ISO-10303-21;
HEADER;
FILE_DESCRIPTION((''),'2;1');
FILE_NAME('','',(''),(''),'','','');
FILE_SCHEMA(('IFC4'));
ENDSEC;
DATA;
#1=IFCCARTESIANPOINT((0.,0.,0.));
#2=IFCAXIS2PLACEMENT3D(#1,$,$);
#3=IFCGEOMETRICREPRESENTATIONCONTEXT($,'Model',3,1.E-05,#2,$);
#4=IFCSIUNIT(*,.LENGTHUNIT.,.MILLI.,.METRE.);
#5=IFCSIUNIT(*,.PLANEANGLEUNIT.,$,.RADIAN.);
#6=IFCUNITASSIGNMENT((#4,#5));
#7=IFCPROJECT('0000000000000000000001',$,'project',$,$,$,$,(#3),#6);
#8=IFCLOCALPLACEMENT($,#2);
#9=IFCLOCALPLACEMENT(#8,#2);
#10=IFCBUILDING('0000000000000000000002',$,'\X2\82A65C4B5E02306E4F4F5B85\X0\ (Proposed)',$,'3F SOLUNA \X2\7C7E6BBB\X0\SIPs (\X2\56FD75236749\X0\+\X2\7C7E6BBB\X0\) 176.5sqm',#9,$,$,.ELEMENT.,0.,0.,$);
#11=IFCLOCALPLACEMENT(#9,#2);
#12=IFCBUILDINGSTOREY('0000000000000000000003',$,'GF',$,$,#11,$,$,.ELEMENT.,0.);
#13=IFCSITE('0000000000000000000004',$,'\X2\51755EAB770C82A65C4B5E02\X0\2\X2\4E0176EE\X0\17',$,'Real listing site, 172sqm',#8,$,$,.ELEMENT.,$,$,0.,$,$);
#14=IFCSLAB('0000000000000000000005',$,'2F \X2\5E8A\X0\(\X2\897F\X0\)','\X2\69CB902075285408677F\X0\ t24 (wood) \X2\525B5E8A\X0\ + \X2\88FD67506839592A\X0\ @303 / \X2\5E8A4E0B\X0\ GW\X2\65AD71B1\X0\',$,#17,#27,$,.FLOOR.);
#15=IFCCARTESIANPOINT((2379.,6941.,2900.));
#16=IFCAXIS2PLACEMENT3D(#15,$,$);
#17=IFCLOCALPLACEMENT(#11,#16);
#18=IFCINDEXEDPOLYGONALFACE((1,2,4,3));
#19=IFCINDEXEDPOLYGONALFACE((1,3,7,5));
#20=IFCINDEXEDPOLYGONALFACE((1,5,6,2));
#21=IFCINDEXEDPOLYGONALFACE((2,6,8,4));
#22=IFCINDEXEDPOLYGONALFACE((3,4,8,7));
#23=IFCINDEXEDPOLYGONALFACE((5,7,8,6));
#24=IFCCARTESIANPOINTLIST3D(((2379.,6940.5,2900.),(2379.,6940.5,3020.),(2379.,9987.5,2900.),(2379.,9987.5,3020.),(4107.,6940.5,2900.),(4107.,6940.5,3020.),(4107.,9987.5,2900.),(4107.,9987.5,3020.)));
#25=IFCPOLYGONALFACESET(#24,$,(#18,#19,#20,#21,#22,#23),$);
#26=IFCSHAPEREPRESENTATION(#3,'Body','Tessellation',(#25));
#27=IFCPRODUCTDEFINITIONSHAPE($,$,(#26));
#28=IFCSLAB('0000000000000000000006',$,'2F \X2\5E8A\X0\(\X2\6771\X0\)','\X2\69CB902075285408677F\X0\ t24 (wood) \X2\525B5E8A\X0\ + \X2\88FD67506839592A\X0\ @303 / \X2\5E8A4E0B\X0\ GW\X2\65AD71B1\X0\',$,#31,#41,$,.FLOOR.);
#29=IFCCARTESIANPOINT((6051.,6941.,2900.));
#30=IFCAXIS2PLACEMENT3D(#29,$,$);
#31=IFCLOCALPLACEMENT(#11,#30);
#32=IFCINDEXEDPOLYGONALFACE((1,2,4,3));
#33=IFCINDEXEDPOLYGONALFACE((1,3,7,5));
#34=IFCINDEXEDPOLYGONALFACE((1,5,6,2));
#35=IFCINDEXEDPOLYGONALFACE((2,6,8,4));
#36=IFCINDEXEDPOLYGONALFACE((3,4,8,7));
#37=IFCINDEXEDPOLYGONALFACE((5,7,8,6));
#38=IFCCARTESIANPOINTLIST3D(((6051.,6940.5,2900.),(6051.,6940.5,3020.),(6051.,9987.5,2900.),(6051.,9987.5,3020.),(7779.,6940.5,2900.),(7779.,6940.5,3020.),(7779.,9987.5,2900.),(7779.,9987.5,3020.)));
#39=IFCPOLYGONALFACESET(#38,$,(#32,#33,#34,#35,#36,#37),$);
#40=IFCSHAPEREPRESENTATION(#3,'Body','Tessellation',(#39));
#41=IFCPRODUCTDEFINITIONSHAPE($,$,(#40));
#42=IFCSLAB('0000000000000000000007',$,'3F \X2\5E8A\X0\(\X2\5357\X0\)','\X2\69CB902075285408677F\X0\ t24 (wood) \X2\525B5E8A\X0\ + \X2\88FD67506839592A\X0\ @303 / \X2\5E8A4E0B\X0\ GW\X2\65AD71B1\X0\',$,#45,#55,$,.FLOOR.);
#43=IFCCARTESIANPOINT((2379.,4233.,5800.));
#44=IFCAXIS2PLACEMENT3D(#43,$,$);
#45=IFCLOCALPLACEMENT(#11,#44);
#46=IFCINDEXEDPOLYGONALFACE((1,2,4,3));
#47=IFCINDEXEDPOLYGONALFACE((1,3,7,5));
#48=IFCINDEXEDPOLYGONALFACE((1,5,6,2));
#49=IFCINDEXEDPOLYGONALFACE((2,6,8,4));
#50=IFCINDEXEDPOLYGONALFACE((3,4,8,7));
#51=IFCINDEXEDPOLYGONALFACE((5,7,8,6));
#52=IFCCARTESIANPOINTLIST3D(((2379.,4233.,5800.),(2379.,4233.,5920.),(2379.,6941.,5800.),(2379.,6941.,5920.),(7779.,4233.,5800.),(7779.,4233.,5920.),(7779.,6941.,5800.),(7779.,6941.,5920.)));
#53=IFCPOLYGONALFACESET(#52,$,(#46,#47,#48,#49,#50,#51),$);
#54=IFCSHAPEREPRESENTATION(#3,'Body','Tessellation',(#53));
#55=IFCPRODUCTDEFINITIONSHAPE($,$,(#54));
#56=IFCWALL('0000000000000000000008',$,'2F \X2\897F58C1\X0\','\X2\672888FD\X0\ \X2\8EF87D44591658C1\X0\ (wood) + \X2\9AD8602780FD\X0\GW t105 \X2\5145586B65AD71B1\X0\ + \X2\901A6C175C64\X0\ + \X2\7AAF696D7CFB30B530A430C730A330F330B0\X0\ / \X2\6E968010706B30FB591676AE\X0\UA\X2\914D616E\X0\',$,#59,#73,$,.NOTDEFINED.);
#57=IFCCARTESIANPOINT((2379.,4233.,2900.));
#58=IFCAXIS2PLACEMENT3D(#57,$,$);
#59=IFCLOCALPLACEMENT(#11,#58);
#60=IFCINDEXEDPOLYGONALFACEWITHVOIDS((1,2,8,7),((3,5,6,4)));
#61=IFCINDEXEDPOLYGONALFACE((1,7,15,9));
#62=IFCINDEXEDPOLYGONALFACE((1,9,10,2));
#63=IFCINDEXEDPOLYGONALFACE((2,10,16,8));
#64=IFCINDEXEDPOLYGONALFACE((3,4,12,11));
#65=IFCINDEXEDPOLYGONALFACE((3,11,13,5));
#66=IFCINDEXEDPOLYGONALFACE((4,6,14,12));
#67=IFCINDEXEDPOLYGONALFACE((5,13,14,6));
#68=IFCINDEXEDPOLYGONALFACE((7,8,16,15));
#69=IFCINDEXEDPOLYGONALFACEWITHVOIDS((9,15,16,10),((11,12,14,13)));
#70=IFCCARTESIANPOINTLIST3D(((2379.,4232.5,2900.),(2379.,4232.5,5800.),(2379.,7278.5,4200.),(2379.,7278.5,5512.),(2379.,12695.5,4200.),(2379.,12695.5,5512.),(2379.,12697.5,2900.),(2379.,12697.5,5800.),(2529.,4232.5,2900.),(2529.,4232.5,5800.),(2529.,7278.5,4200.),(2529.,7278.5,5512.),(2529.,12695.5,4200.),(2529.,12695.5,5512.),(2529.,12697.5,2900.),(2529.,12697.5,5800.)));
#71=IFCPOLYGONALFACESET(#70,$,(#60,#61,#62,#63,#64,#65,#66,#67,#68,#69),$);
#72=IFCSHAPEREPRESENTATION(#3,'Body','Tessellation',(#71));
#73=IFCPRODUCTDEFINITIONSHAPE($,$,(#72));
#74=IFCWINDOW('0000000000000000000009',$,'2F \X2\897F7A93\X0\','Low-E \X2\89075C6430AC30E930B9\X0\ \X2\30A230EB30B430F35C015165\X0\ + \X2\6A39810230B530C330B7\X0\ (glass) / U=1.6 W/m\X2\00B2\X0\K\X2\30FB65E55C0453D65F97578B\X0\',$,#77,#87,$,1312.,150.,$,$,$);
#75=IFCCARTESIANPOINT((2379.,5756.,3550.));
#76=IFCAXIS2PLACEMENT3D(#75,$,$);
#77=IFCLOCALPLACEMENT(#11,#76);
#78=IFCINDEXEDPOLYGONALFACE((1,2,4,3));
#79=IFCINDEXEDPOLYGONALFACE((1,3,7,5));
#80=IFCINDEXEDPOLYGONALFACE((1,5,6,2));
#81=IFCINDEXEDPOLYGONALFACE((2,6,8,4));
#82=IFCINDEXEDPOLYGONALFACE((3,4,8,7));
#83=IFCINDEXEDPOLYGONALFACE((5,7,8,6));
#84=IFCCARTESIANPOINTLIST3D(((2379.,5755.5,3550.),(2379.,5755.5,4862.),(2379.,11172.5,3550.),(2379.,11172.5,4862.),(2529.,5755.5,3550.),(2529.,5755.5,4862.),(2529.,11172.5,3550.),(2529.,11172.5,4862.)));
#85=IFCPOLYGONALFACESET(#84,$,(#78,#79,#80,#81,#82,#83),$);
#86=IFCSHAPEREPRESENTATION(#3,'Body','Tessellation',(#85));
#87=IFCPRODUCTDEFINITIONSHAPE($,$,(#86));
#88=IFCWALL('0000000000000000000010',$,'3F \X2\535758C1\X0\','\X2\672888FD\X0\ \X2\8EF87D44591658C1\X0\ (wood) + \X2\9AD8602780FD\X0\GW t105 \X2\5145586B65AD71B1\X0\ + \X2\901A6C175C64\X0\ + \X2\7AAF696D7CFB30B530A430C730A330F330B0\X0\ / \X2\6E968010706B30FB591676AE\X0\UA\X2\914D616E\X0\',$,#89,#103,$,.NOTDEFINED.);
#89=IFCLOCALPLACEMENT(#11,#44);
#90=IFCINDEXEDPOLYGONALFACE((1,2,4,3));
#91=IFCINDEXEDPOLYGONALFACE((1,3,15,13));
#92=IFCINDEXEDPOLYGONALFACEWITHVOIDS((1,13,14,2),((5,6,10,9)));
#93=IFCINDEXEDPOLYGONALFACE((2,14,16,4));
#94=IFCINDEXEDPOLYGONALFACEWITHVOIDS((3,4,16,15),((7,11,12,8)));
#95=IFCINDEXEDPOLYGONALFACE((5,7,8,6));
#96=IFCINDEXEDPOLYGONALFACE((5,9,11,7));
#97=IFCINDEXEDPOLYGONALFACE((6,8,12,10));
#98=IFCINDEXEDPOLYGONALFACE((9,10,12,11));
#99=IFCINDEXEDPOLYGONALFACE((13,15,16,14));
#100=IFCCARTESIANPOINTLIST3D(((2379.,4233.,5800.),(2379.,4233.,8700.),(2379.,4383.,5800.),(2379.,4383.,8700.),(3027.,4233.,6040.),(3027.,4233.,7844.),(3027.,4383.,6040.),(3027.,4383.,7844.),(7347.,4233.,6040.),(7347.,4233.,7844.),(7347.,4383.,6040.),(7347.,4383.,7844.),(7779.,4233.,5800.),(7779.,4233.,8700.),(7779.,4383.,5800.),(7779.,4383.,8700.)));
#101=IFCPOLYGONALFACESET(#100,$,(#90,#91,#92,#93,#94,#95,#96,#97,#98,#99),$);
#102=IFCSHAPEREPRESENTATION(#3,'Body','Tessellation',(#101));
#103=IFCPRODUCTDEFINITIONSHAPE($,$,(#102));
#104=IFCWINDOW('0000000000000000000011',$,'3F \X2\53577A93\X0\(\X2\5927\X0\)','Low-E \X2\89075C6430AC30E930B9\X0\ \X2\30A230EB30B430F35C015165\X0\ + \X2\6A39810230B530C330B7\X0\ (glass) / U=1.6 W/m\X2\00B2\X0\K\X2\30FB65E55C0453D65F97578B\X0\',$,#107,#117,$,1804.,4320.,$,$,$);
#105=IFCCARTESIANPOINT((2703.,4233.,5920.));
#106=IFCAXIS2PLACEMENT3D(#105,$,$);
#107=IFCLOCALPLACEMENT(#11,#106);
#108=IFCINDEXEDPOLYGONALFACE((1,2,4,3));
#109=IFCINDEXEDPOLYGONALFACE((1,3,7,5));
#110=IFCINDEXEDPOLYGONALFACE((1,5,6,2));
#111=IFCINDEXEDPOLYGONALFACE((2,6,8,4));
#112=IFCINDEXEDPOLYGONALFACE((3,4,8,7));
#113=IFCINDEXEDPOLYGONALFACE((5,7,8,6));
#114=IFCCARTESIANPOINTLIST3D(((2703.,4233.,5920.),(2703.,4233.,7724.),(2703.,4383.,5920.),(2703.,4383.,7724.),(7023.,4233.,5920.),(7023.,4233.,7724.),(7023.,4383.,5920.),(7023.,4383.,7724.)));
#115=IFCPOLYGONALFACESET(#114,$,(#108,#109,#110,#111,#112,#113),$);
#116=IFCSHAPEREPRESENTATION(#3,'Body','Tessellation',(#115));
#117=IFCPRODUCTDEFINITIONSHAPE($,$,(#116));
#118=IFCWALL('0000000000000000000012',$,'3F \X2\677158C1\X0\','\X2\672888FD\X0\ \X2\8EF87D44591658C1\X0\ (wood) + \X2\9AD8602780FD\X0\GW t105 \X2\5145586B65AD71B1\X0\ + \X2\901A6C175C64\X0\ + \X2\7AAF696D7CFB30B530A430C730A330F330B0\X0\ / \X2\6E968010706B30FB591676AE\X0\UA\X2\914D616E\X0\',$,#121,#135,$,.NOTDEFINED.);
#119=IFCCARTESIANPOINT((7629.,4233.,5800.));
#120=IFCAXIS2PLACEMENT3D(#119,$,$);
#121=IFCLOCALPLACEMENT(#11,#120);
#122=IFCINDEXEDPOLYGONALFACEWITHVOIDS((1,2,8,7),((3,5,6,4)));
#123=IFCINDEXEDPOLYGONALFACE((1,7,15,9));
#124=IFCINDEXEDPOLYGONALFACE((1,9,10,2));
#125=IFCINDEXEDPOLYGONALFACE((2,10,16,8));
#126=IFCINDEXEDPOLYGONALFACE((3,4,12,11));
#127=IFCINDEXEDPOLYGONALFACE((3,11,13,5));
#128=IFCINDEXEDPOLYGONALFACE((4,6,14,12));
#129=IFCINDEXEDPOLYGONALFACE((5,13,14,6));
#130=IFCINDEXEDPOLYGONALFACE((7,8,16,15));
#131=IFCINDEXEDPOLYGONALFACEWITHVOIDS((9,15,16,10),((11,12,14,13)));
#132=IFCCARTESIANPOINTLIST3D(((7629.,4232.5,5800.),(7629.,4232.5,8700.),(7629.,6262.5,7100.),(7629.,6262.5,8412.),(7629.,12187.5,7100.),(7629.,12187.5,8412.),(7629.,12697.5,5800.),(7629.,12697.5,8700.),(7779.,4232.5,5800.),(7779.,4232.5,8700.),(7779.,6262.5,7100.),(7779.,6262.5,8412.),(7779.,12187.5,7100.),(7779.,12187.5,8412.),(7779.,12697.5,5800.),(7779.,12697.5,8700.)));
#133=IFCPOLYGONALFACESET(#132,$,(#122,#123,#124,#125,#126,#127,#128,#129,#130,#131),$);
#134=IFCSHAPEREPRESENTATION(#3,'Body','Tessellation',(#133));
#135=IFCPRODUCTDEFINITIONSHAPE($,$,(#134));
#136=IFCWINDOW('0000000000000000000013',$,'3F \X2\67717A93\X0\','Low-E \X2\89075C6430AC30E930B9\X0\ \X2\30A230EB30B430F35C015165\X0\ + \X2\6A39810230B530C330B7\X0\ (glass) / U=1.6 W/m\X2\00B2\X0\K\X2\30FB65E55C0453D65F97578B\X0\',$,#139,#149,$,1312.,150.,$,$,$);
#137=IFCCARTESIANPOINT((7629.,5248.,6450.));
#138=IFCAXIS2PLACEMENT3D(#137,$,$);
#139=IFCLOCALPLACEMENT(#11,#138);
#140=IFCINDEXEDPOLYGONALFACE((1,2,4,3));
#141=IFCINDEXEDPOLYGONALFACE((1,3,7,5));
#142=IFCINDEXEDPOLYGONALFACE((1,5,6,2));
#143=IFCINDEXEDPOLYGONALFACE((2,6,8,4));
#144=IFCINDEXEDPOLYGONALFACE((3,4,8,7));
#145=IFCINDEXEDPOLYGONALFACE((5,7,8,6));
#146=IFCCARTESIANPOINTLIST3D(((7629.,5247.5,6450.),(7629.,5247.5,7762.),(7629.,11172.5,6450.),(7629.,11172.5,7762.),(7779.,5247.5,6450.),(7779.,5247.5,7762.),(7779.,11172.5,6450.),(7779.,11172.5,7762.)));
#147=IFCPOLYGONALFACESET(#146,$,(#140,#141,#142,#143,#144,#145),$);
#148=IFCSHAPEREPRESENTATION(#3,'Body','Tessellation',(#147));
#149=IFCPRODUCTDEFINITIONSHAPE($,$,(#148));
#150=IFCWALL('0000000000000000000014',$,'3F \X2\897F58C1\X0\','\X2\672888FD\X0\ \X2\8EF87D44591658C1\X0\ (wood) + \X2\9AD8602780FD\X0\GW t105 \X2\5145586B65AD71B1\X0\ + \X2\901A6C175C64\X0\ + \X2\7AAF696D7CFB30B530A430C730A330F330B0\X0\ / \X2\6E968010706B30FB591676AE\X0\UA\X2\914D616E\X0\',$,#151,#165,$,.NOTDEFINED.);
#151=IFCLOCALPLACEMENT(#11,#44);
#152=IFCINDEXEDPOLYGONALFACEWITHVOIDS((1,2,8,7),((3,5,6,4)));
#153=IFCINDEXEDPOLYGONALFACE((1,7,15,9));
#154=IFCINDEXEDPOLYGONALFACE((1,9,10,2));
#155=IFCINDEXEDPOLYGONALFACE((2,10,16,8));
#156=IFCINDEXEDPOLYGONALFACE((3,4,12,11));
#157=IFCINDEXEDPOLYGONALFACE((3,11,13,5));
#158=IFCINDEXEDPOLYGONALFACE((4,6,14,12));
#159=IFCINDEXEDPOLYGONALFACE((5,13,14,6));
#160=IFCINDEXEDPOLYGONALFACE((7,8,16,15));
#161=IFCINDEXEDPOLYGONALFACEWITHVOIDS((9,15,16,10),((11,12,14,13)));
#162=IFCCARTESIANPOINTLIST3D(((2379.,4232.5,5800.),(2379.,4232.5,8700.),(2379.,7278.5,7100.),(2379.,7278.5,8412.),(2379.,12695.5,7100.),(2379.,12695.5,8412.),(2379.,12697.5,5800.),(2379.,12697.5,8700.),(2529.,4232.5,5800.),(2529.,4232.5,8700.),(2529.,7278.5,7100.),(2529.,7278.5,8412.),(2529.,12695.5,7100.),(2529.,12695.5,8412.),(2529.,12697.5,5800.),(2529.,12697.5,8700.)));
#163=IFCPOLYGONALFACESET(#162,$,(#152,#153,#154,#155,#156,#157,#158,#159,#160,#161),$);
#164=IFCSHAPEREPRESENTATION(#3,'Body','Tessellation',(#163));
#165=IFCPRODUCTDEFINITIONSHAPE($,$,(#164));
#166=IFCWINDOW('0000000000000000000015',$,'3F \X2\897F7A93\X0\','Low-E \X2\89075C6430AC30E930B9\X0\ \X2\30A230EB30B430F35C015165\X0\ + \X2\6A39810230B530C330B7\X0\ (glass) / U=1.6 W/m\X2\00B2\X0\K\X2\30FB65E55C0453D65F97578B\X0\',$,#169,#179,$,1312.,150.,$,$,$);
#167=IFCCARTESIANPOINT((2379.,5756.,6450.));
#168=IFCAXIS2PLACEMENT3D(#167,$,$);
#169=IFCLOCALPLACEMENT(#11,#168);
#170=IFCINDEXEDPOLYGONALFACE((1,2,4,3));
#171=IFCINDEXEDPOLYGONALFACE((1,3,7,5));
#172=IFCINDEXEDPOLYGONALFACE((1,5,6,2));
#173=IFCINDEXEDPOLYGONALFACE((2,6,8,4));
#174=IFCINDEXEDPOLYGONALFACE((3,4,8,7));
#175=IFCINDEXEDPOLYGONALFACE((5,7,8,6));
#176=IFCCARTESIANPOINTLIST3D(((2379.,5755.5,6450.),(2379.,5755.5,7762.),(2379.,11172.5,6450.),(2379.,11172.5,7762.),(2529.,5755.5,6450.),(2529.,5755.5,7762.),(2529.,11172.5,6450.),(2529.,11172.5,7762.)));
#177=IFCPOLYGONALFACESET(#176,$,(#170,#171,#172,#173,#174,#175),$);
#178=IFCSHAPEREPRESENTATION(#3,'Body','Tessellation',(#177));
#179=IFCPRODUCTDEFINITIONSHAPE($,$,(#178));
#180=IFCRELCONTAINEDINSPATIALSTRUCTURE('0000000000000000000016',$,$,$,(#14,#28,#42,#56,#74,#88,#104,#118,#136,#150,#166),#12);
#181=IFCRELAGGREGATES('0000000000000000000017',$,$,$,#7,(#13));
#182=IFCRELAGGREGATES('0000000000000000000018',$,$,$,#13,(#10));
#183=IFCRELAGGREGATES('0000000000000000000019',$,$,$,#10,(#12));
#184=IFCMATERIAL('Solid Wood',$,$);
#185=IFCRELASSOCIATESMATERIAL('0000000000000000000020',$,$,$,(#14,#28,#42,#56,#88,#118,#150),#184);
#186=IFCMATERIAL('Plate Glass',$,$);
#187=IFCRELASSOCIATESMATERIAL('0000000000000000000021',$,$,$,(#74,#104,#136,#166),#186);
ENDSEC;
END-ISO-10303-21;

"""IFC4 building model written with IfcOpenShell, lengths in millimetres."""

from ifc_helpers import new_model, si_unit, frame, frame_2d, origin, place, context, project, spatial, rectangle, extrude, material, element, fill, save


model = new_model("IFC4")

# Units and contexts
model_context = context("Model", 3, precision=1e-05, world=origin())
ifc_project = project(units=[si_unit("LENGTHUNIT", "METRE", prefix="MILLI"), si_unit("PLANEANGLEUNIT", "RADIAN")], contexts=[model_context])

# Site, building, storey
site_placement = place(None, origin())
site = spatial("IfcSite", under=ifc_project, at=site_placement, Name="兵庫県芦屋市2丁目17", ObjectType="Real listing site, 172sqm", CompositionType="ELEMENT", RefElevation=0.0)
building_placement = place(site_placement, origin())
building = spatial("IfcBuilding", under=site, at=building_placement, Name="芦屋市の住宅 (Proposed)", ObjectType="3F SOLUNA 籾殻SIPs (国産杉+籾殻) 176.5sqm", CompositionType="ELEMENT", ElevationOfRefHeight=0.0, ElevationOfTerrain=0.0)
storey_placement = place(building_placement, origin())
storey = spatial("IfcBuildingStorey", under=building, at=storey_placement, Name="GF", CompositionType="ELEMENT", Elevation=0.0)

# Slabs
ifc_material_1 = material(Name="Solid Wood")
slab_1_placement = place(storey_placement, frame((2379.0, 6941.0, 2900.0)))
element("IfcSlab", 1, at=slab_1_placement, inside=storey, material=ifc_material_1, Name="2F 床(西)", Description="構造用合板 t24 (wood) 剛床 + 製材根太 @303 / 床下 GW断熱", PredefinedType="FLOOR", context=model_context, shape_type="SweptSolid", body=[
    extrude(rectangle(XDim=1728.0, YDim=3047.0, at=frame_2d((864.0, 1523.0))), frame((2379.0, 6941.0, 2900.0)), (0.0, 0.0, 1.0), 120.0),
])
slab_2_placement = place(storey_placement, frame((6051.0, 6941.0, 2900.0)))
element("IfcSlab", 2, at=slab_2_placement, inside=storey, material=ifc_material_1, Name="2F 床(東)", Description="構造用合板 t24 (wood) 剛床 + 製材根太 @303 / 床下 GW断熱", PredefinedType="FLOOR", context=model_context, shape_type="SweptSolid", body=[
    extrude(rectangle(XDim=1728.0, YDim=3047.0, at=frame_2d((864.0, 1523.0))), frame((6051.0, 6941.0, 2900.0)), (0.0, 0.0, 1.0), 120.0),
])
slab_3_placement = place(storey_placement, frame((2379.0, 4233.0, 5800.0)))
element("IfcSlab", 3, at=slab_3_placement, inside=storey, material=ifc_material_1, Name="3F 床(南)", Description="構造用合板 t24 (wood) 剛床 + 製材根太 @303 / 床下 GW断熱", PredefinedType="FLOOR", context=model_context, shape_type="SweptSolid", body=[
    extrude(rectangle(XDim=5400.0, YDim=2708.0, at=frame_2d((2700.0, 1354.0))), frame((2379.0, 4233.0, 5800.0)), (0.0, 0.0, 1.0), 120.0),
])

# Walls, openings, windows
wall_1_placement = place(storey_placement, frame((2379.0, 4233.0, 2900.0)))
wall_1 = element("IfcWall", 4, at=wall_1_placement, inside=storey, material=ifc_material_1, Name="2F 西壁", Description="木製 軸組外壁 (wood) + 高性能GW t105 充填断熱 + 通気層 + 窯業系サイディング / 準耐火・外皮UA配慮", PredefinedType="NOTDEFINED", context=model_context, shape_type="SweptSolid", body=[
    extrude(rectangle(XDim=150.0, YDim=8465.0, at=frame_2d((75.0, 4232.0))), frame((2379.0, 4233.0, 2900.0)), (0.0, 0.0, 1.0), 2900.0),
])
opening_1_placement = place(storey_placement, frame((2379.0, 5756.0, 3550.0)))
opening_1 = element("IfcOpeningElement", 5, at=opening_1_placement, cuts=wall_1, PredefinedType="NOTDEFINED", context=model_context, shape_type="SweptSolid", body=[
    extrude(rectangle(XDim=150.0, YDim=5417.0, at=frame_2d((75.0, 2708.0))), frame((2379.0, 5756.0, 3550.0)), (0.0, 0.0, 1.0), 1312.0),
])
ifc_material_2 = material(Name="Plate Glass")
window_1_placement = place(storey_placement, frame((2379.0, 5756.0, 3550.0)))
window_1 = element("IfcWindow", 6, at=window_1_placement, inside=storey, material=ifc_material_2, Name="2F 西窓", Description="Low-E 複層ガラス アルゴン封入 + 樹脂サッシ (glass) / U=1.6 W/m²K・日射取得型", OverallHeight=1312.0, OverallWidth=150.0, context=model_context, shape_type="SweptSolid", body=[
    extrude(rectangle(XDim=150.0, YDim=5417.0, at=frame_2d((75.0, 2708.0))), frame((2379.0, 5756.0, 3550.0)), (0.0, 0.0, 1.0), 1312.0),
])
fill(opening_1, window_1)
wall_2_placement = place(storey_placement, frame((2379.0, 4233.0, 5800.0)))
wall_2 = element("IfcWall", 7, at=wall_2_placement, inside=storey, material=ifc_material_1, Name="3F 南壁", Description="木製 軸組外壁 (wood) + 高性能GW t105 充填断熱 + 通気層 + 窯業系サイディング / 準耐火・外皮UA配慮", PredefinedType="NOTDEFINED", context=model_context, shape_type="SweptSolid", body=[
    extrude(rectangle(XDim=5400.0, YDim=150.0, at=frame_2d((2700.0, 75.0))), frame((2379.0, 4233.0, 5800.0)), (0.0, 0.0, 1.0), 2900.0),
])
opening_2_placement = place(storey_placement, frame((2703.0, 4233.0, 5920.0)))
opening_2 = element("IfcOpeningElement", 8, at=opening_2_placement, cuts=wall_2, PredefinedType="NOTDEFINED", context=model_context, shape_type="SweptSolid", body=[
    extrude(rectangle(XDim=4320.0, YDim=150.0, at=frame_2d((2160.0, 75.0))), frame((2703.0, 4233.0, 5920.0)), (0.0, 0.0, 1.0), 1804.0),
])
window_2_placement = place(storey_placement, frame((2703.0, 4233.0, 5920.0)))
window_2 = element("IfcWindow", 9, at=window_2_placement, inside=storey, material=ifc_material_2, Name="3F 南窓(大)", Description="Low-E 複層ガラス アルゴン封入 + 樹脂サッシ (glass) / U=1.6 W/m²K・日射取得型", OverallHeight=1804.0, OverallWidth=4320.0, context=model_context, shape_type="SweptSolid", body=[
    extrude(rectangle(XDim=4320.0, YDim=150.0, at=frame_2d((2160.0, 75.0))), frame((2703.0, 4233.0, 5920.0)), (0.0, 0.0, 1.0), 1804.0),
])
fill(opening_2, window_2)
wall_3_placement = place(storey_placement, frame((7629.0, 4233.0, 5800.0)))
wall_3 = element("IfcWall", 10, at=wall_3_placement, inside=storey, material=ifc_material_1, Name="3F 東壁", Description="木製 軸組外壁 (wood) + 高性能GW t105 充填断熱 + 通気層 + 窯業系サイディング / 準耐火・外皮UA配慮", PredefinedType="NOTDEFINED", context=model_context, shape_type="SweptSolid", body=[
    extrude(rectangle(XDim=150.0, YDim=8465.0, at=frame_2d((75.0, 4232.0))), frame((7629.0, 4233.0, 5800.0)), (0.0, 0.0, 1.0), 2900.0),
])
opening_3_placement = place(storey_placement, frame((7629.0, 5248.0, 6450.0)))
opening_3 = element("IfcOpeningElement", 11, at=opening_3_placement, cuts=wall_3, PredefinedType="NOTDEFINED", context=model_context, shape_type="SweptSolid", body=[
    extrude(rectangle(XDim=150.0, YDim=5925.0, at=frame_2d((75.0, 2962.0))), frame((7629.0, 5248.0, 6450.0)), (0.0, 0.0, 1.0), 1312.0),
])
window_3_placement = place(storey_placement, frame((7629.0, 5248.0, 6450.0)))
window_3 = element("IfcWindow", 12, at=window_3_placement, inside=storey, material=ifc_material_2, Name="3F 東窓", Description="Low-E 複層ガラス アルゴン封入 + 樹脂サッシ (glass) / U=1.6 W/m²K・日射取得型", OverallHeight=1312.0, OverallWidth=150.0, context=model_context, shape_type="SweptSolid", body=[
    extrude(rectangle(XDim=150.0, YDim=5925.0, at=frame_2d((75.0, 2962.0))), frame((7629.0, 5248.0, 6450.0)), (0.0, 0.0, 1.0), 1312.0),
])
fill(opening_3, window_3)
wall_4_placement = place(storey_placement, frame((2379.0, 4233.0, 5800.0)))
wall_4 = element("IfcWall", 13, at=wall_4_placement, inside=storey, material=ifc_material_1, Name="3F 西壁", Description="木製 軸組外壁 (wood) + 高性能GW t105 充填断熱 + 通気層 + 窯業系サイディング / 準耐火・外皮UA配慮", PredefinedType="NOTDEFINED", context=model_context, shape_type="SweptSolid", body=[
    extrude(rectangle(XDim=150.0, YDim=8465.0, at=frame_2d((75.0, 4232.0))), frame((2379.0, 4233.0, 5800.0)), (0.0, 0.0, 1.0), 2900.0),
])
opening_4_placement = place(storey_placement, frame((2379.0, 5756.0, 6450.0)))
opening_4 = element("IfcOpeningElement", 14, at=opening_4_placement, cuts=wall_4, PredefinedType="NOTDEFINED", context=model_context, shape_type="SweptSolid", body=[
    extrude(rectangle(XDim=150.0, YDim=5417.0, at=frame_2d((75.0, 2708.0))), frame((2379.0, 5756.0, 6450.0)), (0.0, 0.0, 1.0), 1312.0),
])
window_4_placement = place(storey_placement, frame((2379.0, 5756.0, 6450.0)))
window_4 = element("IfcWindow", 15, at=window_4_placement, inside=storey, material=ifc_material_2, Name="3F 西窓", Description="Low-E 複層ガラス アルゴン封入 + 樹脂サッシ (glass) / U=1.6 W/m²K・日射取得型", OverallHeight=1312.0, OverallWidth=150.0, context=model_context, shape_type="SweptSolid", body=[
    extrude(rectangle(XDim=150.0, YDim=5417.0, at=frame_2d((75.0, 2708.0))), frame((2379.0, 5756.0, 6450.0)), (0.0, 0.0, 1.0), 1312.0),
])
fill(opening_4, window_4)

save(model, "model.ifc")
